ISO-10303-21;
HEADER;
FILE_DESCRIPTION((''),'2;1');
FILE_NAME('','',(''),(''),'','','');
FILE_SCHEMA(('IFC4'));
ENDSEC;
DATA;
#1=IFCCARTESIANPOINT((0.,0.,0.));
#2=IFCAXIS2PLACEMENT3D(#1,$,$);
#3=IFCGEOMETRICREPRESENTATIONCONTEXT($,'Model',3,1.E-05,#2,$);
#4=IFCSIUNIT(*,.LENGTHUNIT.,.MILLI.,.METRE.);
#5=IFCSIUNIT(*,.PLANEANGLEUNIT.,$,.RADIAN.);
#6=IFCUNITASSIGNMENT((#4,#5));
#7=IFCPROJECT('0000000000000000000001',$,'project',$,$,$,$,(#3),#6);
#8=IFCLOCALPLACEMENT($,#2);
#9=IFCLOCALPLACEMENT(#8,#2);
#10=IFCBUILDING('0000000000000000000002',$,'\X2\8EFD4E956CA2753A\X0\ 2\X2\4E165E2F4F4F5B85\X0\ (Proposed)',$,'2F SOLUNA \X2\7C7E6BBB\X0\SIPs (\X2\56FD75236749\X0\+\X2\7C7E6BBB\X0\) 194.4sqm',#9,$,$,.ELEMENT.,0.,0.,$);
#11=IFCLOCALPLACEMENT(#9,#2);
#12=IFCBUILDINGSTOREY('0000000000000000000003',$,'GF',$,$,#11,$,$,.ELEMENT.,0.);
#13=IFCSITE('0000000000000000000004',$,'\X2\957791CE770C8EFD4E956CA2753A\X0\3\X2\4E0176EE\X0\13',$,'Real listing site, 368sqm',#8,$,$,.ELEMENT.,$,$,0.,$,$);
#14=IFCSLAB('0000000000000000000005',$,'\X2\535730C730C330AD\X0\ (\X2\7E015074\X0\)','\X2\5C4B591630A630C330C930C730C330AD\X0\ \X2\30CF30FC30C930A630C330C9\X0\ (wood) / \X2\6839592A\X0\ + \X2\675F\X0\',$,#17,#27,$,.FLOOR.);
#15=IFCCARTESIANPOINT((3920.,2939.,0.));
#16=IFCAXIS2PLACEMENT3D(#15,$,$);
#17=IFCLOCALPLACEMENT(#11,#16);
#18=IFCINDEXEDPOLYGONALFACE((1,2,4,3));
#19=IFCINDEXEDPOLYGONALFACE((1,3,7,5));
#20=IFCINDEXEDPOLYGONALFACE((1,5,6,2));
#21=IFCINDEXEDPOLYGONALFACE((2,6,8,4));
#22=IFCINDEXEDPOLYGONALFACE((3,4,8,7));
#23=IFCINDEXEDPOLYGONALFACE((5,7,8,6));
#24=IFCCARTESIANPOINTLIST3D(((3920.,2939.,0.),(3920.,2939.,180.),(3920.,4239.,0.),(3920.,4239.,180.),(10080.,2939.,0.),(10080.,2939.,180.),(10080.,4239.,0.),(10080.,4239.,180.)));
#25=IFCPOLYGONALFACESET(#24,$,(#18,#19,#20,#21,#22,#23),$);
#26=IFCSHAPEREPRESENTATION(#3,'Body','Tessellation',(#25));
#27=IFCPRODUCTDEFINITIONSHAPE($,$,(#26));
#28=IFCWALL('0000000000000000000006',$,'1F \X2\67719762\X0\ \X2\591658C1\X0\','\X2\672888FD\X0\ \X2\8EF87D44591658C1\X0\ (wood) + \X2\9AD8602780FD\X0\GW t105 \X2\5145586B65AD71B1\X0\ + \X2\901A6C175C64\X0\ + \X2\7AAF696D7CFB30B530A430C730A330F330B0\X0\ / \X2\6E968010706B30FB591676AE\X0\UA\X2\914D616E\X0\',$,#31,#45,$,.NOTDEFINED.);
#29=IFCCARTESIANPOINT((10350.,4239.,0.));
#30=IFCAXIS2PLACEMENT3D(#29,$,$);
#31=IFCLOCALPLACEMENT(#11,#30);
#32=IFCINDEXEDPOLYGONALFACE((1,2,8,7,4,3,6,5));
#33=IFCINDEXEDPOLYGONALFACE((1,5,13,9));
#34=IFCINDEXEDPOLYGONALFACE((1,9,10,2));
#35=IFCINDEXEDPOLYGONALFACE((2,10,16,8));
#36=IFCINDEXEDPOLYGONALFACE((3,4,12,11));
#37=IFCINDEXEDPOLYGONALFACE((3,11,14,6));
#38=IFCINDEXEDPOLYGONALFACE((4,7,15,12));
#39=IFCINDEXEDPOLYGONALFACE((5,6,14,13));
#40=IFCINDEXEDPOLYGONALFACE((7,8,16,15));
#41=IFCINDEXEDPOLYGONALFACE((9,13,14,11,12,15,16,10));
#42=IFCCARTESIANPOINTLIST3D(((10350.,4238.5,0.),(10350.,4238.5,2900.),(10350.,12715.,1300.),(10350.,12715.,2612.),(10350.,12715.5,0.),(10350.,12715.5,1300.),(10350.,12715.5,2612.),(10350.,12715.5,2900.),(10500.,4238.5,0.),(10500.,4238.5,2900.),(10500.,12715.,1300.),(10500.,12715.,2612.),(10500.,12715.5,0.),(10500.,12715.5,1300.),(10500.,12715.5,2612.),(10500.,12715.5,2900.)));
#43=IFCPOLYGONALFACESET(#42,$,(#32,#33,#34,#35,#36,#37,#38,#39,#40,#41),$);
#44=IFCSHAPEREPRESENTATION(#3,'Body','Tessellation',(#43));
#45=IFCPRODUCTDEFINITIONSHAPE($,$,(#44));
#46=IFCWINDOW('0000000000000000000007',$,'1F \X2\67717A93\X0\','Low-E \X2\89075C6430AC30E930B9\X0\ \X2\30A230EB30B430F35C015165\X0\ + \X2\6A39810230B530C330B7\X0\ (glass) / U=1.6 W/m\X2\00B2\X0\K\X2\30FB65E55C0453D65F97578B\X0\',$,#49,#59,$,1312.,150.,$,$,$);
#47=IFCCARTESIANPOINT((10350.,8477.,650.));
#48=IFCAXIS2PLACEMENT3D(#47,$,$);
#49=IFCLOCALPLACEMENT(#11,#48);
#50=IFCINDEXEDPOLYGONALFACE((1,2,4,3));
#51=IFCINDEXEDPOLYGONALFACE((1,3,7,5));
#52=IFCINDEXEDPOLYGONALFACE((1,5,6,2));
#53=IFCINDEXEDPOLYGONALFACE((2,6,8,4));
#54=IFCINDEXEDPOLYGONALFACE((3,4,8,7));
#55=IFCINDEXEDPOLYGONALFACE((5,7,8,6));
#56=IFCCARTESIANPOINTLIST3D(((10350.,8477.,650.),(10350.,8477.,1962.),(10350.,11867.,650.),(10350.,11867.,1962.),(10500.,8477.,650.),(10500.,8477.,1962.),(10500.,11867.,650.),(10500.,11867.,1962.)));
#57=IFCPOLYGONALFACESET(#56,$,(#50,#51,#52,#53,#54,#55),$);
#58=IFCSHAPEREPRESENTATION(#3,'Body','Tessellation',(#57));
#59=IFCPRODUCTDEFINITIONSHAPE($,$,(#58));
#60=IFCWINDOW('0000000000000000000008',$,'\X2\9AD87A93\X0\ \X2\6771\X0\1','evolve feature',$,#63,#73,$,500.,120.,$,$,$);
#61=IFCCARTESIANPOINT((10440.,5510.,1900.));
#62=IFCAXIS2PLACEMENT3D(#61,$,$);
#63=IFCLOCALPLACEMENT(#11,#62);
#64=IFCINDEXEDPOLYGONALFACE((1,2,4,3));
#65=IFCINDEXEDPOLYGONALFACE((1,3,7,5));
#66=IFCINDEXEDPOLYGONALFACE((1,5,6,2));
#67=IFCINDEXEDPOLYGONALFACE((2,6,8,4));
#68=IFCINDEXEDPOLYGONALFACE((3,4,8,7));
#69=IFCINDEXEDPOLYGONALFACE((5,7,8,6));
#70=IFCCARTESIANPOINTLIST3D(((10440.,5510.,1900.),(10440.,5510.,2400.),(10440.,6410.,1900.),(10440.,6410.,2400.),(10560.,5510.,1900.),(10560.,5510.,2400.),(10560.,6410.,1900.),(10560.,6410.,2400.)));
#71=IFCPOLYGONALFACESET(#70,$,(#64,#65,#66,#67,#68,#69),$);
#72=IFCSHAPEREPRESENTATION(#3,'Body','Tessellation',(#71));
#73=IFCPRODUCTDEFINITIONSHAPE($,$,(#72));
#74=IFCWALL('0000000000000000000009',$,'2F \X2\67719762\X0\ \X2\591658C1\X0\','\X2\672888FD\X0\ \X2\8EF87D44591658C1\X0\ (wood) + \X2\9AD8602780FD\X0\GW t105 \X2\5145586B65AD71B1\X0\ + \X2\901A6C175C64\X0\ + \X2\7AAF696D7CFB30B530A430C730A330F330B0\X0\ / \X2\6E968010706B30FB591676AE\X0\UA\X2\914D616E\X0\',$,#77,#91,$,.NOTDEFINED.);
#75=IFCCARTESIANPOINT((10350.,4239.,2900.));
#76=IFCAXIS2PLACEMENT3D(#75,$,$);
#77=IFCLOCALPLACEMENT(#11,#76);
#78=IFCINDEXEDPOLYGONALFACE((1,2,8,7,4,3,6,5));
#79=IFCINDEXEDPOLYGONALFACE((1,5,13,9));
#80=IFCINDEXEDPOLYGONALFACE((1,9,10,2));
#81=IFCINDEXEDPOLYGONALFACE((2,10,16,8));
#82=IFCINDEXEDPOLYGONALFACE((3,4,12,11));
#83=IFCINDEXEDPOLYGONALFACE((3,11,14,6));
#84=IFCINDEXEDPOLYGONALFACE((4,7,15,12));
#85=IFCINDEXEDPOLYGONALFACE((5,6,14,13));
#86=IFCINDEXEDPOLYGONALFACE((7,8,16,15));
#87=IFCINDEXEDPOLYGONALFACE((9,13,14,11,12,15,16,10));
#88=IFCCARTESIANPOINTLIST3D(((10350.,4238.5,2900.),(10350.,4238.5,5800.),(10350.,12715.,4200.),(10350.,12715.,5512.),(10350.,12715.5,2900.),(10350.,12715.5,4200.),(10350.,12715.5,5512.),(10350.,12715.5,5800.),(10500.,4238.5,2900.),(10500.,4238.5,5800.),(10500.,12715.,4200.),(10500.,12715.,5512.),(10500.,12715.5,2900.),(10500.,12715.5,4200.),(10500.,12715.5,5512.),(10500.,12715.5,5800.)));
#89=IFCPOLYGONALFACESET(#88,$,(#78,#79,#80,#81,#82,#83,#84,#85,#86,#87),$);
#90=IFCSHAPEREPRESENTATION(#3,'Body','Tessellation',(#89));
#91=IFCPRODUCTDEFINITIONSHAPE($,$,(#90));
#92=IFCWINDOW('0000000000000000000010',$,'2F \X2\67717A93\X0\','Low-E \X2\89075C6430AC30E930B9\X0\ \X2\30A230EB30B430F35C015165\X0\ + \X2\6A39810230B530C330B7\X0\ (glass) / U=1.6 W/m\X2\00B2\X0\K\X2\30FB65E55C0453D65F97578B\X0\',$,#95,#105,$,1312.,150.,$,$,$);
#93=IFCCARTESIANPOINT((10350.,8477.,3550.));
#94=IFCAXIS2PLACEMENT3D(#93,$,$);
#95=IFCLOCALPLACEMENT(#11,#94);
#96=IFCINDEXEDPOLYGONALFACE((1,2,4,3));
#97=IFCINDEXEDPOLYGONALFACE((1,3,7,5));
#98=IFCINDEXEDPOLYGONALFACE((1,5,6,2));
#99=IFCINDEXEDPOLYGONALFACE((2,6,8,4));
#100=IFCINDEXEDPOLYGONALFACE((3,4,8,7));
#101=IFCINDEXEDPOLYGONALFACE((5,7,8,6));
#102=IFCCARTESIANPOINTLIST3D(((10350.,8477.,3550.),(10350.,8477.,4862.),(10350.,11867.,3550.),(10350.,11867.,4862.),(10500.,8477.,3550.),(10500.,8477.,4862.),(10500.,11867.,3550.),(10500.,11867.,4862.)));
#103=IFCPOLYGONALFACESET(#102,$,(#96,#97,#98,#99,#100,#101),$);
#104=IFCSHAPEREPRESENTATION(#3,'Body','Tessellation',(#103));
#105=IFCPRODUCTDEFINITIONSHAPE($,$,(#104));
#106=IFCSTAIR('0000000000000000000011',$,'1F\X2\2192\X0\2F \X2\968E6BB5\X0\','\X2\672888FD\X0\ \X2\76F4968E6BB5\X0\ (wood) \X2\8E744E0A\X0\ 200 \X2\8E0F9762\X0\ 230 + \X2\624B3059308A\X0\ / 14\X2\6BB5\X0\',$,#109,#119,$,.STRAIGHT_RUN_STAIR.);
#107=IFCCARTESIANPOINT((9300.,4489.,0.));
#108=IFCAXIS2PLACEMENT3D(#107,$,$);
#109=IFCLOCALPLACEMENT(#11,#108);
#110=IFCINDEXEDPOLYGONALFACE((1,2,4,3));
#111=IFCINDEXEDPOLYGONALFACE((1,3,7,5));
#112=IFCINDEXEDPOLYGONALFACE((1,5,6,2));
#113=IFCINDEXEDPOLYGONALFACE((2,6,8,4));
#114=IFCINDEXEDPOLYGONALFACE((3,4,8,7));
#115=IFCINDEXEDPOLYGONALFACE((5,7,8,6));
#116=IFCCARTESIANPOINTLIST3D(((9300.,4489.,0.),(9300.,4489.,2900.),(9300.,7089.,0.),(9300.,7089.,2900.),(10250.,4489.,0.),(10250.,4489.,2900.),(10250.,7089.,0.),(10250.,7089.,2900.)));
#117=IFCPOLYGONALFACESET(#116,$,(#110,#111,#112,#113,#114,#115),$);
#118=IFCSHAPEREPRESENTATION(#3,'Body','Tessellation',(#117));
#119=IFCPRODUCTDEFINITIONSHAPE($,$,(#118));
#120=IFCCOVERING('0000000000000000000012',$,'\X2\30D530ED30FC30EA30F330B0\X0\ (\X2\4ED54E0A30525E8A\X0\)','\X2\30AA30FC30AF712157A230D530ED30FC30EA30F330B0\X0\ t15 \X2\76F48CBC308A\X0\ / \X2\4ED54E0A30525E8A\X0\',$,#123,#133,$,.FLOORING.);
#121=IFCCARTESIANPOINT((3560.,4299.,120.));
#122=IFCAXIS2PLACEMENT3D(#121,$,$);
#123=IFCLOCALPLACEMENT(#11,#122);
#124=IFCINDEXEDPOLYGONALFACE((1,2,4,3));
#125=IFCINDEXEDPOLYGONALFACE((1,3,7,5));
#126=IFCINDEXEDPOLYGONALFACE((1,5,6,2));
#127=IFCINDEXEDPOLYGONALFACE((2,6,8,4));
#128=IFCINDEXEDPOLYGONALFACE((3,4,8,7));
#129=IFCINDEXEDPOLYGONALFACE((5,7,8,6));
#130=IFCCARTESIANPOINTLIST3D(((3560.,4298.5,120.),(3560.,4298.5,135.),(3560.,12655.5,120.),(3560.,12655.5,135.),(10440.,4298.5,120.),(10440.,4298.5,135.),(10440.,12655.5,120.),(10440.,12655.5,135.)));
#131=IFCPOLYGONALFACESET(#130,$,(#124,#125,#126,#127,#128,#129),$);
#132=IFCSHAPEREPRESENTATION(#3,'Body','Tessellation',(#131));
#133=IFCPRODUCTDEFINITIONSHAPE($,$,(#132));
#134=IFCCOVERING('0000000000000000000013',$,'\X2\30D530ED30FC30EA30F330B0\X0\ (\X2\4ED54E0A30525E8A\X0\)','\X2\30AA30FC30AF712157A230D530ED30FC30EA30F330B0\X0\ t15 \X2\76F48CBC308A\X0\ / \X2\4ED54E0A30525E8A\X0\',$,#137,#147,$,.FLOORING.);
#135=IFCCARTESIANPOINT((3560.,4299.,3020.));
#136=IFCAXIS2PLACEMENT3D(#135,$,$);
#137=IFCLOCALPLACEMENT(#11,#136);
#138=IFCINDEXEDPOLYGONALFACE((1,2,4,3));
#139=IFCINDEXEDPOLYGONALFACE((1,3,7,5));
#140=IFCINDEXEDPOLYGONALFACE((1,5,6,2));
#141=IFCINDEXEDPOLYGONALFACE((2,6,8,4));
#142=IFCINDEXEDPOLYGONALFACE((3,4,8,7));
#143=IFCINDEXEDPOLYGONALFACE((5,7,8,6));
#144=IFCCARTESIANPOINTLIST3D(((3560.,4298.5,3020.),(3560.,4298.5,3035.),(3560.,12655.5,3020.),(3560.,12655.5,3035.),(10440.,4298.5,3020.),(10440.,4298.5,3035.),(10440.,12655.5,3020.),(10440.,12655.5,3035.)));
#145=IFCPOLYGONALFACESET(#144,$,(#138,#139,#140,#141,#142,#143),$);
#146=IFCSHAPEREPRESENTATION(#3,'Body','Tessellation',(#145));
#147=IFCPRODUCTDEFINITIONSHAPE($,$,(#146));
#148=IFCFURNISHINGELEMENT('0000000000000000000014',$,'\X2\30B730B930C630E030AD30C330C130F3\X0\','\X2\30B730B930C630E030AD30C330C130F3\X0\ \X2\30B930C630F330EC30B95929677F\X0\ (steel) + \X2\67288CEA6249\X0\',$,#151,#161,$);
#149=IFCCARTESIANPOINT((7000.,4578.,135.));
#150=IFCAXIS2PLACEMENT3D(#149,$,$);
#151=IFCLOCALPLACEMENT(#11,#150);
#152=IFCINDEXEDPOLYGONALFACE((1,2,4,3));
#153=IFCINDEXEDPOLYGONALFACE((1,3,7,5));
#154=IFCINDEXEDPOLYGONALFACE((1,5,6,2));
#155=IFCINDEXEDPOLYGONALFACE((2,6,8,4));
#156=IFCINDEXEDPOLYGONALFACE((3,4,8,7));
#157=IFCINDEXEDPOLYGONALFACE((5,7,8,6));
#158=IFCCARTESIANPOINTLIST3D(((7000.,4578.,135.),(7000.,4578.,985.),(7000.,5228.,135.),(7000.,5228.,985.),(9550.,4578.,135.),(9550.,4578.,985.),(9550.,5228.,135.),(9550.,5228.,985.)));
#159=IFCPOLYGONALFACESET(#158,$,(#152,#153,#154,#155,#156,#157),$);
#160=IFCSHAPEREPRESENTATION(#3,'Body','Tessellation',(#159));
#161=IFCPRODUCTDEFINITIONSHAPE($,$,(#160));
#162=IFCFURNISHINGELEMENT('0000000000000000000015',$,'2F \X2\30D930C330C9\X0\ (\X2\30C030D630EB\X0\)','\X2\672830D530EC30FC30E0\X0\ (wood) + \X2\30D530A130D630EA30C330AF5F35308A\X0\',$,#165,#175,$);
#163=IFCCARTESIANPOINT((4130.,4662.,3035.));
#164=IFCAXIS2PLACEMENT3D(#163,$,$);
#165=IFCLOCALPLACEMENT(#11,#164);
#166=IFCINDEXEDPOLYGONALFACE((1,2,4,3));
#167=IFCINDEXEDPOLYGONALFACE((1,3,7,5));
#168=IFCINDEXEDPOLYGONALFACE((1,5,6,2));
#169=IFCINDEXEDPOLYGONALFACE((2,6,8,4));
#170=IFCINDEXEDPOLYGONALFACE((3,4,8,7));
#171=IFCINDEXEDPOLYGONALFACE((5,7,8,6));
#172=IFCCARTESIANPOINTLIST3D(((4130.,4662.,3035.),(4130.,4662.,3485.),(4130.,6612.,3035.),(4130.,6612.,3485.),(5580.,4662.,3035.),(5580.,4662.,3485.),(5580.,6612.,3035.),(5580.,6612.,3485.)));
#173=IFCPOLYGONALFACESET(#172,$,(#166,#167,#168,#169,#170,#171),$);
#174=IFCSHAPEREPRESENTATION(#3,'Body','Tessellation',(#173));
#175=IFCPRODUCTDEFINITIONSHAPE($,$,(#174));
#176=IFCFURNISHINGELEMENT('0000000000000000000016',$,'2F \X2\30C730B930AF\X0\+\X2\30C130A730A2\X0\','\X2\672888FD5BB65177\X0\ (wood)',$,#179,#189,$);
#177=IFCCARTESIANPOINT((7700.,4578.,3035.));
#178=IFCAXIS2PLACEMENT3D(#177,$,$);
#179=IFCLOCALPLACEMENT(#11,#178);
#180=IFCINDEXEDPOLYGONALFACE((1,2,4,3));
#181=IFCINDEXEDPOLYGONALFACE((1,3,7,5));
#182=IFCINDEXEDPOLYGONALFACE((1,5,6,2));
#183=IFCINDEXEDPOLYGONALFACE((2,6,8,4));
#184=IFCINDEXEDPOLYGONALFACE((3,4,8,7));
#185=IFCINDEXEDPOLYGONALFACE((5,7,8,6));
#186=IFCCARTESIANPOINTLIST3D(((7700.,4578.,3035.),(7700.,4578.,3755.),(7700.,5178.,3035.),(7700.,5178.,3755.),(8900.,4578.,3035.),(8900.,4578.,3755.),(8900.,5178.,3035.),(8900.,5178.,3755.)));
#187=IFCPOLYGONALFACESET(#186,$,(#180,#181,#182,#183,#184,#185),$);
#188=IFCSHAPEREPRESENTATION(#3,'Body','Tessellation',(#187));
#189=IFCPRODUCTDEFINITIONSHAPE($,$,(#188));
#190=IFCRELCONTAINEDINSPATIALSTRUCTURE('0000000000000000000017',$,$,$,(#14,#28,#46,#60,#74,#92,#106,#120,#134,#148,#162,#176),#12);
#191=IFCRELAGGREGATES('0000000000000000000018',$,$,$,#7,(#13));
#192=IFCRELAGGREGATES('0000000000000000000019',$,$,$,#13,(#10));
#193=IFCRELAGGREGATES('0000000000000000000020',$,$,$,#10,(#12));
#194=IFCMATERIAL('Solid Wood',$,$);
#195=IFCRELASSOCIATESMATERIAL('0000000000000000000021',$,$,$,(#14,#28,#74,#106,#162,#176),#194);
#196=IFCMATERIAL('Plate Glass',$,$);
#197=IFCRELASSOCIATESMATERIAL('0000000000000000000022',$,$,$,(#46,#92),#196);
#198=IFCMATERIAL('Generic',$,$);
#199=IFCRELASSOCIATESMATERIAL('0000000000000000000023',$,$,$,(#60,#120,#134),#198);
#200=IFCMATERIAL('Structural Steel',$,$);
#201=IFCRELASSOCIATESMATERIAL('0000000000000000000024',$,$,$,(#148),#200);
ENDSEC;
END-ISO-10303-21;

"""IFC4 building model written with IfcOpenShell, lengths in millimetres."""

from ifc_helpers import new_model, si_unit, frame, frame_2d, origin, place, context, project, spatial, rectangle, extrude, material, element, fill, save


model = new_model("IFC4")

# Units and contexts
model_context = context("Model", 3, precision=1e-05, world=origin())
ifc_project = project(units=[si_unit("LENGTHUNIT", "METRE", prefix="MILLI"), si_unit("PLANEANGLEUNIT", "RADIAN")], contexts=[model_context])

# Site, building, storey
site_placement = place(None, origin())
site = spatial("IfcSite", under=ifc_project, at=site_placement, Name="長野県軽井沢町3丁目13", ObjectType="Real listing site, 368sqm", CompositionType="ELEMENT", RefElevation=0.0)
building_placement = place(site_placement, origin())
building = spatial("IfcBuilding", under=site, at=building_placement, Name="軽井沢町 2世帯住宅 (Proposed)", ObjectType="2F SOLUNA 籾殻SIPs (国産杉+籾殻) 194.4sqm", CompositionType="ELEMENT", ElevationOfRefHeight=0.0, ElevationOfTerrain=0.0)
storey_placement = place(building_placement, origin())
storey = spatial("IfcBuildingStorey", under=building, at=storey_placement, Name="GF", CompositionType="ELEMENT", Elevation=0.0)

# Slab
ifc_material_1 = material(Name="Solid Wood")
slab_placement = place(storey_placement, frame((3920.0, 2939.0, 0.0)))
element("IfcSlab", 1, at=slab_placement, inside=storey, material=ifc_material_1, Name="南デッキ (縁側)", Description="屋外ウッドデッキ ハードウッド (wood) / 根太 + 束", PredefinedType="FLOOR", context=model_context, shape_type="SweptSolid", body=[
    extrude(rectangle(XDim=6160.0, YDim=1300.0, at=frame_2d((3080.0, 650.0))), frame((3920.0, 2939.0, 0.0)), (0.0, 0.0, 1.0), 180.0),
])

# Wall, openings, windows
wall_1_placement = place(storey_placement, frame((10350.0, 4239.0, 0.0)))
wall_1 = element("IfcWall", 2, at=wall_1_placement, inside=storey, material=ifc_material_1, Name="1F 東面 外壁", Description="木製 軸組外壁 (wood) + 高性能GW t105 充填断熱 + 通気層 + 窯業系サイディング / 準耐火・外皮UA配慮", PredefinedType="NOTDEFINED", context=model_context, shape_type="SweptSolid", body=[
    extrude(rectangle(XDim=150.0, YDim=8477.0, at=frame_2d((75.0, 4238.0))), frame((10350.0, 4239.0, 0.0)), (0.0, 0.0, 1.0), 2900.0),
])
opening_1_placement = place(storey_placement, frame((10350.0, 8477.0, 650.0)))
opening_1 = element("IfcOpeningElement", 3, at=opening_1_placement, cuts=wall_1, PredefinedType="NOTDEFINED", context=model_context, shape_type="SweptSolid", body=[
    extrude(rectangle(XDim=150.0, YDim=3390.0, at=frame_2d((75.0, 1695.0))), frame((10350.0, 8477.0, 650.0)), (0.0, 0.0, 1.0), 1312.0),
])
opening_2_placement = place(storey_placement, frame((10440.0, 5510.0, 1900.0)))
opening_2 = element("IfcOpeningElement", 4, at=opening_2_placement, cuts=wall_1, PredefinedType="NOTDEFINED", context=model_context, shape_type="SweptSolid", body=[
    extrude(rectangle(XDim=120.0, YDim=900.0, at=frame_2d((60.0, 450.0))), frame((10440.0, 5510.0, 1900.0)), (0.0, 0.0, 1.0), 500.0),
])
ifc_material_2 = material(Name="Plate Glass")
window_1_placement = place(storey_placement, frame((10350.0, 8477.0, 650.0)))
window_1 = element("IfcWindow", 5, at=window_1_placement, inside=storey, material=ifc_material_2, Name="1F 東窓", Description="Low-E 複層ガラス アルゴン封入 + 樹脂サッシ (glass) / U=1.6 W/m²K・日射取得型", OverallHeight=1312.0, OverallWidth=150.0, context=model_context, shape_type="SweptSolid", body=[
    extrude(rectangle(XDim=150.0, YDim=3390.0, at=frame_2d((75.0, 1695.0))), frame((10350.0, 8477.0, 650.0)), (0.0, 0.0, 1.0), 1312.0),
])
fill(opening_1, window_1)
ifc_material_3 = material(Name="Generic")
window_2_placement = place(storey_placement, frame((10440.0, 5510.0, 1900.0)))
window_2 = element("IfcWindow", 6, at=window_2_placement, inside=storey, material=ifc_material_3, Name="高窓 東1", Description="evolve feature", OverallHeight=500.0, OverallWidth=120.0, context=model_context, shape_type="SweptSolid", body=[
    extrude(rectangle(XDim=120.0, YDim=900.0, at=frame_2d((60.0, 450.0))), frame((10440.0, 5510.0, 1900.0)), (0.0, 0.0, 1.0), 500.0),
])
fill(opening_2, window_2)

# Wall, opening, window
wall_2_placement = place(storey_placement, frame((10350.0, 4239.0, 2900.0)))
wall_2 = element("IfcWall", 7, at=wall_2_placement, inside=storey, material=ifc_material_1, Name="2F 東面 外壁", Description="木製 軸組外壁 (wood) + 高性能GW t105 充填断熱 + 通気層 + 窯業系サイディング / 準耐火・外皮UA配慮", PredefinedType="NOTDEFINED", context=model_context, shape_type="SweptSolid", body=[
    extrude(rectangle(XDim=150.0, YDim=8477.0, at=frame_2d((75.0, 4238.0))), frame((10350.0, 4239.0, 2900.0)), (0.0, 0.0, 1.0), 2900.0),
])
opening_3_placement = place(storey_placement, frame((10350.0, 8477.0, 3550.0)))
opening_3 = element("IfcOpeningElement", 8, at=opening_3_placement, cuts=wall_2, PredefinedType="NOTDEFINED", context=model_context, shape_type="SweptSolid", body=[
    extrude(rectangle(XDim=150.0, YDim=3390.0, at=frame_2d((75.0, 1695.0))), frame((10350.0, 8477.0, 3550.0)), (0.0, 0.0, 1.0), 1312.0),
])
window_3_placement = place(storey_placement, frame((10350.0, 8477.0, 3550.0)))
window_3 = element("IfcWindow", 9, at=window_3_placement, inside=storey, material=ifc_material_2, Name="2F 東窓", Description="Low-E 複層ガラス アルゴン封入 + 樹脂サッシ (glass) / U=1.6 W/m²K・日射取得型", OverallHeight=1312.0, OverallWidth=150.0, context=model_context, shape_type="SweptSolid", body=[
    extrude(rectangle(XDim=150.0, YDim=3390.0, at=frame_2d((75.0, 1695.0))), frame((10350.0, 8477.0, 3550.0)), (0.0, 0.0, 1.0), 1312.0),
])
fill(opening_3, window_3)

# Stair
stair_placement = place(storey_placement, frame((9300.0, 4489.0, 0.0)))
element("IfcStair", 10, at=stair_placement, inside=storey, material=ifc_material_1, Name="1F→2F 階段", Description="木製 直階段 (wood) 蹴上 200 踏面 230 + 手すり / 14段", PredefinedType="STRAIGHT_RUN_STAIR", context=model_context, shape_type="SweptSolid", body=[
    extrude(rectangle(XDim=950.0, YDim=2600.0, at=frame_2d((475.0, 1300.0))), frame((9300.0, 4489.0, 0.0)), (0.0, 0.0, 1.0), 2900.0),
])

# Coverings
covering_1_placement = place(storey_placement, frame((3560.0, 4299.0, 120.0)))
element("IfcCovering", 11, at=covering_1_placement, inside=storey, material=ifc_material_3, Name="フローリング (仕上げ床)", Description="オーク無垢フローリング t15 直貼り / 仕上げ床", PredefinedType="FLOORING", context=model_context, shape_type="SweptSolid", body=[
    extrude(rectangle(XDim=6880.0, YDim=8357.0, at=frame_2d((3440.0, 4178.0))), frame((3560.0, 4299.0, 120.0)), (0.0, 0.0, 1.0), 15.0),
])
covering_2_placement = place(storey_placement, frame((3560.0, 4299.0, 3020.0)))
element("IfcCovering", 12, at=covering_2_placement, inside=storey, material=ifc_material_3, Name="フローリング (仕上げ床)", Description="オーク無垢フローリング t15 直貼り / 仕上げ床", PredefinedType="FLOORING", context=model_context, shape_type="SweptSolid", body=[
    extrude(rectangle(XDim=6880.0, YDim=8357.0, at=frame_2d((3440.0, 4178.0))), frame((3560.0, 4299.0, 3020.0)), (0.0, 0.0, 1.0), 15.0),
])

# Furnishing elements
ifc_material_4 = material(Name="Structural Steel")
furnishing_1_placement = place(storey_placement, frame((7000.0, 4578.0, 135.0)))
element("IfcFurnishingElement", 13, at=furnishing_1_placement, inside=storey, material=ifc_material_4, Name="システムキッチン", Description="システムキッチン ステンレス天板 (steel) + 木質扉", context=model_context, shape_type="SweptSolid", body=[
    extrude(rectangle(XDim=2550.0, YDim=650.0, at=frame_2d((1275.0, 325.0))), frame((7000.0, 4578.0, 135.0)), (0.0, 0.0, 1.0), 850.0),
])
furnishing_2_placement = place(storey_placement, frame((4130.0, 4662.0, 3035.0)))
element("IfcFurnishingElement", 14, at=furnishing_2_placement, inside=storey, material=ifc_material_1, Name="2F ベッド (ダブル)", Description="木フレーム (wood) + ファブリック張り", context=model_context, shape_type="SweptSolid", body=[
    extrude(rectangle(XDim=1450.0, YDim=1950.0, at=frame_2d((725.0, 975.0))), frame((4130.0, 4662.0, 3035.0)), (0.0, 0.0, 1.0), 450.0),
])
furnishing_3_placement = place(storey_placement, frame((7700.0, 4578.0, 3035.0)))
element("IfcFurnishingElement", 15, at=furnishing_3_placement, inside=storey, material=ifc_material_1, Name="2F デスク+チェア", Description="木製家具 (wood)", context=model_context, shape_type="SweptSolid", body=[
    extrude(rectangle(XDim=1200.0, YDim=600.0, at=frame_2d((600.0, 300.0))), frame((7700.0, 4578.0, 3035.0)), (0.0, 0.0, 1.0), 720.0),
])

save(model, "model.ifc")
